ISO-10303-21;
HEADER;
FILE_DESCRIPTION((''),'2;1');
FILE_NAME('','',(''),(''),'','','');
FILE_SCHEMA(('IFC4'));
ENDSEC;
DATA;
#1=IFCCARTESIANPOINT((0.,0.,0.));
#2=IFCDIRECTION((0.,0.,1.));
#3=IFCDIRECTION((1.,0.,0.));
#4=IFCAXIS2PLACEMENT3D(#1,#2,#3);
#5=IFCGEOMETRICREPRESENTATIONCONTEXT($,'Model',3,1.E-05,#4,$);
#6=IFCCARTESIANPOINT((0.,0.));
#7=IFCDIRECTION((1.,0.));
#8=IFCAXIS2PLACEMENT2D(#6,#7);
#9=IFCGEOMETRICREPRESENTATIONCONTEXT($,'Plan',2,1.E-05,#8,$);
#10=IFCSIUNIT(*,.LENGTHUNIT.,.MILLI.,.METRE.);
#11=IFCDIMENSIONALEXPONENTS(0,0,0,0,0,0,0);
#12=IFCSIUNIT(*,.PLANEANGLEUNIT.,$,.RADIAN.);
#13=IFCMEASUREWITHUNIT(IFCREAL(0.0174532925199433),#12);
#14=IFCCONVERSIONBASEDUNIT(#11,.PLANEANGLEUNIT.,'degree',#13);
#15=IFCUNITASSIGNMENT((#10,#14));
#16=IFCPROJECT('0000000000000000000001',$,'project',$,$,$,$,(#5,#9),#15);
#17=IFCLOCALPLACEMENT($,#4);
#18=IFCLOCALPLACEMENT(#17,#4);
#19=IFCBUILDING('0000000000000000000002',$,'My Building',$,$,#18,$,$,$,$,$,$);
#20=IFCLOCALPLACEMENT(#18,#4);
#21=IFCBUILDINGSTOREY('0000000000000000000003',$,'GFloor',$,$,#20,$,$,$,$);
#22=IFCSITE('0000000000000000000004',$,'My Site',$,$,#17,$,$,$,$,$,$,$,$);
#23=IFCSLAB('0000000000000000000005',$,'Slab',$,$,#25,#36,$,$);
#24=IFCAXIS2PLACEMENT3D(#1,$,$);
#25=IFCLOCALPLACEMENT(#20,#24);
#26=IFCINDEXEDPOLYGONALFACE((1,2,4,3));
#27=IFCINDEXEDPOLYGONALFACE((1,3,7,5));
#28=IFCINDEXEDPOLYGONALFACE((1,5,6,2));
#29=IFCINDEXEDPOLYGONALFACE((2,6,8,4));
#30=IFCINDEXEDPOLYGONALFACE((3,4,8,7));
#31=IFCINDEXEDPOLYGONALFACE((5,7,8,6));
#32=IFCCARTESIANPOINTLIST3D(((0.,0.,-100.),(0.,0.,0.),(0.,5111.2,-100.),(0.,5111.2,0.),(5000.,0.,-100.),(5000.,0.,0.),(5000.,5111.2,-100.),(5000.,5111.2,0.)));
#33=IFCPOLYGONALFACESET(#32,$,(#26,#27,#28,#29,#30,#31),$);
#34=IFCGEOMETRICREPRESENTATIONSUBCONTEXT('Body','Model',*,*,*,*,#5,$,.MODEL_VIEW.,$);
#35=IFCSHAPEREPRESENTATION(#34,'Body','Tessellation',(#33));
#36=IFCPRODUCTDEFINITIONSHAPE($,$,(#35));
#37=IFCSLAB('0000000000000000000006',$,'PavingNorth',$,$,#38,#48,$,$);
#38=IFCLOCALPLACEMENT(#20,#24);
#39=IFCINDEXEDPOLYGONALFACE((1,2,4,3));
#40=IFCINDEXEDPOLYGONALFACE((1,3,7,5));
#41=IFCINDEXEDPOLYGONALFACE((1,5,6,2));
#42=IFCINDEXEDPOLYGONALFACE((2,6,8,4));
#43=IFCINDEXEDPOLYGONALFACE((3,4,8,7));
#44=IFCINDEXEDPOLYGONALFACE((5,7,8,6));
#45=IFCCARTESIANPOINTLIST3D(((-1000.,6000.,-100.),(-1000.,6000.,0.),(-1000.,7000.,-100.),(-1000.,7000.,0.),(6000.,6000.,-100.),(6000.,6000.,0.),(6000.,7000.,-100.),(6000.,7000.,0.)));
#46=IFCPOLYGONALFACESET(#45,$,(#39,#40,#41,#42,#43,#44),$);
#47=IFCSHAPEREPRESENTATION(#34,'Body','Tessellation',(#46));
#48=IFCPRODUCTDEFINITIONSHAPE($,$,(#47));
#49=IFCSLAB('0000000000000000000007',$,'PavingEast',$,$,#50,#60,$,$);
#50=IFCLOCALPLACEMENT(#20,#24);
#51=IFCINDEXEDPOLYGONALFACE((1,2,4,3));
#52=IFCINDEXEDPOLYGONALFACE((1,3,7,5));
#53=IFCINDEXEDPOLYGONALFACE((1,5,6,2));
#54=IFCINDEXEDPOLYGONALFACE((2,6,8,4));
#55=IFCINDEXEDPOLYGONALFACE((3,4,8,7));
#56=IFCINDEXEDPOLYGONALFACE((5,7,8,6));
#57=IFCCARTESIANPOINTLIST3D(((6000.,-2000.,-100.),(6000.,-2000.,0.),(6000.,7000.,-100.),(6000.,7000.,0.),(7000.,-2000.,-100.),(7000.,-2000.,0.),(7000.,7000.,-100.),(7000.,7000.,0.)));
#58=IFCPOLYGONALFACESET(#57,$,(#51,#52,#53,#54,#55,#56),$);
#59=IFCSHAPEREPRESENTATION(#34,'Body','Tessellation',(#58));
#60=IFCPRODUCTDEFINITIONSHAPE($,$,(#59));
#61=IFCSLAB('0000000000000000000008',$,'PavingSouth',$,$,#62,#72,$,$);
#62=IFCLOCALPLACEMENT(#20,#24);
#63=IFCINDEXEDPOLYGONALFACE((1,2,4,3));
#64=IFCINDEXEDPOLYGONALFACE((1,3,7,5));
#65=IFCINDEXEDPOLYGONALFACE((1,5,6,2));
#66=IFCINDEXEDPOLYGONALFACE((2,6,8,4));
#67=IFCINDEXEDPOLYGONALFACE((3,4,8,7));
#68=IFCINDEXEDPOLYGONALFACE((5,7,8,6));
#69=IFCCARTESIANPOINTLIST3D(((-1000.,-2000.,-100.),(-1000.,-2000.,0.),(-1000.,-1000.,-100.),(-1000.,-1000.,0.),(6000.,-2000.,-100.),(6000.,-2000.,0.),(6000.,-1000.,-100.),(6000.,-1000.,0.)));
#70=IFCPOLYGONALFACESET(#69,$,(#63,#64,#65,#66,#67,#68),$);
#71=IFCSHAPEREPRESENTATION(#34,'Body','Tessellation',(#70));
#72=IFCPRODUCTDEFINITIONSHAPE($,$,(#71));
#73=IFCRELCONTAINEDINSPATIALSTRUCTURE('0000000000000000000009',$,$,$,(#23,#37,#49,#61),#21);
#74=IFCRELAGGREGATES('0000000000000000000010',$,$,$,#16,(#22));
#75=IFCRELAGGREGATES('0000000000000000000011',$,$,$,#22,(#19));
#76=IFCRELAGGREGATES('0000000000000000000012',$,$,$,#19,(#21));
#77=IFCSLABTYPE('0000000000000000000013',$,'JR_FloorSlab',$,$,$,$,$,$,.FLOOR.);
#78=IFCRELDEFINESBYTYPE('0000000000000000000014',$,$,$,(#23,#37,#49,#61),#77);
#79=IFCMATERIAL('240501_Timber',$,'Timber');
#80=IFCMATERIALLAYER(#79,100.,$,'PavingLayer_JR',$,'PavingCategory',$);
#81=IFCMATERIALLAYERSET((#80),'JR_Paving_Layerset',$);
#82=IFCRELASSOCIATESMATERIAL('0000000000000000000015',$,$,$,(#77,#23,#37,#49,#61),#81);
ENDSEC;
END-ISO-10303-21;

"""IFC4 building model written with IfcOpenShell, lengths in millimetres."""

from ifc_helpers import new_model, entity, si_unit, converted_unit, frame, origin_with_axes, origin_2d_with_axis, place, context, subcontext, project, spatial, line, indexed_curve, outline, extrude, material, layer, layer_set, layer_usage, type_object, element, save


model = new_model("IFC4")

# Units and contexts
model_context = context("Model", 3, precision=1e-05, world=origin_with_axes())
plan_context = context("Plan", 2, precision=1e-05, world=origin_2d_with_axis())
body_context_1 = subcontext(model_context, "Body", "Model", "MODEL_VIEW")
ifc_project = project(units=[si_unit("LENGTHUNIT", "METRE", prefix="MILLI"), converted_unit("PLANEANGLEUNIT", "degree", entity("IfcReal", 0.0174532925199433), si_unit("PLANEANGLEUNIT", "RADIAN"), dimensions=[0, 0, 0, 0, 0, 0, 0])], contexts=[model_context, plan_context])

# Site, building, storey
site_placement = place(None, origin_with_axes())
site = spatial("IfcSite", under=ifc_project, at=site_placement, Name="My Site")
building_placement = place(site_placement, origin_with_axes())
building = spatial("IfcBuilding", under=site, at=building_placement, Name="My Building")
storey_placement = place(building_placement, origin_with_axes())
storey = spatial("IfcBuildingStorey", under=building, at=storey_placement, Name="GFloor")

# Slabs
ifc_material_1 = material(Name="240501_Timber", Category="Timber")
ifc_layer_1 = layer(ifc_material_1, 100.0, Name="PavingLayer_JR", Category="PavingCategory")
ifc_layer_set_1 = layer_set([ifc_layer_1], Name="JR_Paving_Layerset")
ifc_layer_usage_1 = layer_usage(ifc_layer_set_1, "AXIS3", "POSITIVE", 0.0)
slab_type = type_object("IfcSlabType", Name="JR_FloorSlab", PredefinedType="FLOOR", material=ifc_layer_set_1)
slab_1_placement = place(storey_placement, frame((0.0, 0.0, -100.0), z_axis=(0.0, 0.0, 1.0), x_axis=(1.0, 0.0, 0.0)))
element("IfcSlab", 1, at=slab_1_placement, inside=storey, type_object=slab_type, material=ifc_layer_usage_1, Name="Slab", context=body_context_1, shape_type="SweptSolid", body=[
    extrude(outline(indexed_curve([(5000.0, 5111.2), (5000.0, 0.0), (0.0, 0.0), (0.0, 5111.2)], segments=[line(4, 1), line(1, 2), line(2, 3), line(3, 4)], self_intersect=False)), None, (0.0, 0.0, 1.0), 100.0),
])
ifc_layer_usage_2 = layer_usage(ifc_layer_set_1, "AXIS3", "POSITIVE", 0.0)
slab_2_placement = place(storey_placement, frame((0.0, 6000.0, -100.0), z_axis=(0.0, 0.0, 1.0), x_axis=(1.0, 0.0, 0.0)))
element("IfcSlab", 2, at=slab_2_placement, inside=storey, type_object=slab_type, material=ifc_layer_usage_2, Name="PavingNorth", context=body_context_1, shape_type="SweptSolid", body=[
    extrude(outline(indexed_curve([(-1000.0, 0.0), (6000.0, 0.0), (6000.0, 1000.0), (-1000.0, 1000.0)], segments=[line(4, 1), line(1, 2), line(2, 3), line(3, 4)], self_intersect=False)), None, (0.0, 0.0, 1.0), 100.0),
])
ifc_layer_usage_3 = layer_usage(ifc_layer_set_1, "AXIS3", "POSITIVE", 0.0)
slab_3_placement = place(storey_placement, frame((6000.0, 6000.0, -100.0), z_axis=(0.0, 0.0, 1.0), x_axis=(1.0, 0.0, 0.0)))
element("IfcSlab", 3, at=slab_3_placement, inside=storey, type_object=slab_type, material=ifc_layer_usage_3, Name="PavingEast", context=body_context_1, shape_type="SweptSolid", body=[
    extrude(outline(indexed_curve([(0.0, -8000.0), (1000.0, -8000.0), (1000.0, 1000.0), (0.0, 1000.0)], segments=[line(4, 1), line(1, 2), line(2, 3), line(3, 4)], self_intersect=False)), None, (0.0, 0.0, 1.0), 100.0),
])
ifc_layer_usage_4 = layer_usage(ifc_layer_set_1, "AXIS3", "POSITIVE", 0.0)
slab_4_placement = place(storey_placement, frame((0.0, -2000.0, -100.0), z_axis=(0.0, 0.0, 1.0), x_axis=(1.0, 0.0, 0.0)))
element("IfcSlab", 4, at=slab_4_placement, inside=storey, type_object=slab_type, material=ifc_layer_usage_4, Name="PavingSouth", context=body_context_1, shape_type="SweptSolid", body=[
    extrude(outline(indexed_curve([(-1000.0, 0.0), (6000.0, 0.0), (6000.0, 1000.0), (-1000.0, 1000.0)], segments=[line(4, 1), line(1, 2), line(2, 3), line(3, 4)], self_intersect=False)), None, (0.0, 0.0, 1.0), 100.0),
])

save(model, "model.ifc")
